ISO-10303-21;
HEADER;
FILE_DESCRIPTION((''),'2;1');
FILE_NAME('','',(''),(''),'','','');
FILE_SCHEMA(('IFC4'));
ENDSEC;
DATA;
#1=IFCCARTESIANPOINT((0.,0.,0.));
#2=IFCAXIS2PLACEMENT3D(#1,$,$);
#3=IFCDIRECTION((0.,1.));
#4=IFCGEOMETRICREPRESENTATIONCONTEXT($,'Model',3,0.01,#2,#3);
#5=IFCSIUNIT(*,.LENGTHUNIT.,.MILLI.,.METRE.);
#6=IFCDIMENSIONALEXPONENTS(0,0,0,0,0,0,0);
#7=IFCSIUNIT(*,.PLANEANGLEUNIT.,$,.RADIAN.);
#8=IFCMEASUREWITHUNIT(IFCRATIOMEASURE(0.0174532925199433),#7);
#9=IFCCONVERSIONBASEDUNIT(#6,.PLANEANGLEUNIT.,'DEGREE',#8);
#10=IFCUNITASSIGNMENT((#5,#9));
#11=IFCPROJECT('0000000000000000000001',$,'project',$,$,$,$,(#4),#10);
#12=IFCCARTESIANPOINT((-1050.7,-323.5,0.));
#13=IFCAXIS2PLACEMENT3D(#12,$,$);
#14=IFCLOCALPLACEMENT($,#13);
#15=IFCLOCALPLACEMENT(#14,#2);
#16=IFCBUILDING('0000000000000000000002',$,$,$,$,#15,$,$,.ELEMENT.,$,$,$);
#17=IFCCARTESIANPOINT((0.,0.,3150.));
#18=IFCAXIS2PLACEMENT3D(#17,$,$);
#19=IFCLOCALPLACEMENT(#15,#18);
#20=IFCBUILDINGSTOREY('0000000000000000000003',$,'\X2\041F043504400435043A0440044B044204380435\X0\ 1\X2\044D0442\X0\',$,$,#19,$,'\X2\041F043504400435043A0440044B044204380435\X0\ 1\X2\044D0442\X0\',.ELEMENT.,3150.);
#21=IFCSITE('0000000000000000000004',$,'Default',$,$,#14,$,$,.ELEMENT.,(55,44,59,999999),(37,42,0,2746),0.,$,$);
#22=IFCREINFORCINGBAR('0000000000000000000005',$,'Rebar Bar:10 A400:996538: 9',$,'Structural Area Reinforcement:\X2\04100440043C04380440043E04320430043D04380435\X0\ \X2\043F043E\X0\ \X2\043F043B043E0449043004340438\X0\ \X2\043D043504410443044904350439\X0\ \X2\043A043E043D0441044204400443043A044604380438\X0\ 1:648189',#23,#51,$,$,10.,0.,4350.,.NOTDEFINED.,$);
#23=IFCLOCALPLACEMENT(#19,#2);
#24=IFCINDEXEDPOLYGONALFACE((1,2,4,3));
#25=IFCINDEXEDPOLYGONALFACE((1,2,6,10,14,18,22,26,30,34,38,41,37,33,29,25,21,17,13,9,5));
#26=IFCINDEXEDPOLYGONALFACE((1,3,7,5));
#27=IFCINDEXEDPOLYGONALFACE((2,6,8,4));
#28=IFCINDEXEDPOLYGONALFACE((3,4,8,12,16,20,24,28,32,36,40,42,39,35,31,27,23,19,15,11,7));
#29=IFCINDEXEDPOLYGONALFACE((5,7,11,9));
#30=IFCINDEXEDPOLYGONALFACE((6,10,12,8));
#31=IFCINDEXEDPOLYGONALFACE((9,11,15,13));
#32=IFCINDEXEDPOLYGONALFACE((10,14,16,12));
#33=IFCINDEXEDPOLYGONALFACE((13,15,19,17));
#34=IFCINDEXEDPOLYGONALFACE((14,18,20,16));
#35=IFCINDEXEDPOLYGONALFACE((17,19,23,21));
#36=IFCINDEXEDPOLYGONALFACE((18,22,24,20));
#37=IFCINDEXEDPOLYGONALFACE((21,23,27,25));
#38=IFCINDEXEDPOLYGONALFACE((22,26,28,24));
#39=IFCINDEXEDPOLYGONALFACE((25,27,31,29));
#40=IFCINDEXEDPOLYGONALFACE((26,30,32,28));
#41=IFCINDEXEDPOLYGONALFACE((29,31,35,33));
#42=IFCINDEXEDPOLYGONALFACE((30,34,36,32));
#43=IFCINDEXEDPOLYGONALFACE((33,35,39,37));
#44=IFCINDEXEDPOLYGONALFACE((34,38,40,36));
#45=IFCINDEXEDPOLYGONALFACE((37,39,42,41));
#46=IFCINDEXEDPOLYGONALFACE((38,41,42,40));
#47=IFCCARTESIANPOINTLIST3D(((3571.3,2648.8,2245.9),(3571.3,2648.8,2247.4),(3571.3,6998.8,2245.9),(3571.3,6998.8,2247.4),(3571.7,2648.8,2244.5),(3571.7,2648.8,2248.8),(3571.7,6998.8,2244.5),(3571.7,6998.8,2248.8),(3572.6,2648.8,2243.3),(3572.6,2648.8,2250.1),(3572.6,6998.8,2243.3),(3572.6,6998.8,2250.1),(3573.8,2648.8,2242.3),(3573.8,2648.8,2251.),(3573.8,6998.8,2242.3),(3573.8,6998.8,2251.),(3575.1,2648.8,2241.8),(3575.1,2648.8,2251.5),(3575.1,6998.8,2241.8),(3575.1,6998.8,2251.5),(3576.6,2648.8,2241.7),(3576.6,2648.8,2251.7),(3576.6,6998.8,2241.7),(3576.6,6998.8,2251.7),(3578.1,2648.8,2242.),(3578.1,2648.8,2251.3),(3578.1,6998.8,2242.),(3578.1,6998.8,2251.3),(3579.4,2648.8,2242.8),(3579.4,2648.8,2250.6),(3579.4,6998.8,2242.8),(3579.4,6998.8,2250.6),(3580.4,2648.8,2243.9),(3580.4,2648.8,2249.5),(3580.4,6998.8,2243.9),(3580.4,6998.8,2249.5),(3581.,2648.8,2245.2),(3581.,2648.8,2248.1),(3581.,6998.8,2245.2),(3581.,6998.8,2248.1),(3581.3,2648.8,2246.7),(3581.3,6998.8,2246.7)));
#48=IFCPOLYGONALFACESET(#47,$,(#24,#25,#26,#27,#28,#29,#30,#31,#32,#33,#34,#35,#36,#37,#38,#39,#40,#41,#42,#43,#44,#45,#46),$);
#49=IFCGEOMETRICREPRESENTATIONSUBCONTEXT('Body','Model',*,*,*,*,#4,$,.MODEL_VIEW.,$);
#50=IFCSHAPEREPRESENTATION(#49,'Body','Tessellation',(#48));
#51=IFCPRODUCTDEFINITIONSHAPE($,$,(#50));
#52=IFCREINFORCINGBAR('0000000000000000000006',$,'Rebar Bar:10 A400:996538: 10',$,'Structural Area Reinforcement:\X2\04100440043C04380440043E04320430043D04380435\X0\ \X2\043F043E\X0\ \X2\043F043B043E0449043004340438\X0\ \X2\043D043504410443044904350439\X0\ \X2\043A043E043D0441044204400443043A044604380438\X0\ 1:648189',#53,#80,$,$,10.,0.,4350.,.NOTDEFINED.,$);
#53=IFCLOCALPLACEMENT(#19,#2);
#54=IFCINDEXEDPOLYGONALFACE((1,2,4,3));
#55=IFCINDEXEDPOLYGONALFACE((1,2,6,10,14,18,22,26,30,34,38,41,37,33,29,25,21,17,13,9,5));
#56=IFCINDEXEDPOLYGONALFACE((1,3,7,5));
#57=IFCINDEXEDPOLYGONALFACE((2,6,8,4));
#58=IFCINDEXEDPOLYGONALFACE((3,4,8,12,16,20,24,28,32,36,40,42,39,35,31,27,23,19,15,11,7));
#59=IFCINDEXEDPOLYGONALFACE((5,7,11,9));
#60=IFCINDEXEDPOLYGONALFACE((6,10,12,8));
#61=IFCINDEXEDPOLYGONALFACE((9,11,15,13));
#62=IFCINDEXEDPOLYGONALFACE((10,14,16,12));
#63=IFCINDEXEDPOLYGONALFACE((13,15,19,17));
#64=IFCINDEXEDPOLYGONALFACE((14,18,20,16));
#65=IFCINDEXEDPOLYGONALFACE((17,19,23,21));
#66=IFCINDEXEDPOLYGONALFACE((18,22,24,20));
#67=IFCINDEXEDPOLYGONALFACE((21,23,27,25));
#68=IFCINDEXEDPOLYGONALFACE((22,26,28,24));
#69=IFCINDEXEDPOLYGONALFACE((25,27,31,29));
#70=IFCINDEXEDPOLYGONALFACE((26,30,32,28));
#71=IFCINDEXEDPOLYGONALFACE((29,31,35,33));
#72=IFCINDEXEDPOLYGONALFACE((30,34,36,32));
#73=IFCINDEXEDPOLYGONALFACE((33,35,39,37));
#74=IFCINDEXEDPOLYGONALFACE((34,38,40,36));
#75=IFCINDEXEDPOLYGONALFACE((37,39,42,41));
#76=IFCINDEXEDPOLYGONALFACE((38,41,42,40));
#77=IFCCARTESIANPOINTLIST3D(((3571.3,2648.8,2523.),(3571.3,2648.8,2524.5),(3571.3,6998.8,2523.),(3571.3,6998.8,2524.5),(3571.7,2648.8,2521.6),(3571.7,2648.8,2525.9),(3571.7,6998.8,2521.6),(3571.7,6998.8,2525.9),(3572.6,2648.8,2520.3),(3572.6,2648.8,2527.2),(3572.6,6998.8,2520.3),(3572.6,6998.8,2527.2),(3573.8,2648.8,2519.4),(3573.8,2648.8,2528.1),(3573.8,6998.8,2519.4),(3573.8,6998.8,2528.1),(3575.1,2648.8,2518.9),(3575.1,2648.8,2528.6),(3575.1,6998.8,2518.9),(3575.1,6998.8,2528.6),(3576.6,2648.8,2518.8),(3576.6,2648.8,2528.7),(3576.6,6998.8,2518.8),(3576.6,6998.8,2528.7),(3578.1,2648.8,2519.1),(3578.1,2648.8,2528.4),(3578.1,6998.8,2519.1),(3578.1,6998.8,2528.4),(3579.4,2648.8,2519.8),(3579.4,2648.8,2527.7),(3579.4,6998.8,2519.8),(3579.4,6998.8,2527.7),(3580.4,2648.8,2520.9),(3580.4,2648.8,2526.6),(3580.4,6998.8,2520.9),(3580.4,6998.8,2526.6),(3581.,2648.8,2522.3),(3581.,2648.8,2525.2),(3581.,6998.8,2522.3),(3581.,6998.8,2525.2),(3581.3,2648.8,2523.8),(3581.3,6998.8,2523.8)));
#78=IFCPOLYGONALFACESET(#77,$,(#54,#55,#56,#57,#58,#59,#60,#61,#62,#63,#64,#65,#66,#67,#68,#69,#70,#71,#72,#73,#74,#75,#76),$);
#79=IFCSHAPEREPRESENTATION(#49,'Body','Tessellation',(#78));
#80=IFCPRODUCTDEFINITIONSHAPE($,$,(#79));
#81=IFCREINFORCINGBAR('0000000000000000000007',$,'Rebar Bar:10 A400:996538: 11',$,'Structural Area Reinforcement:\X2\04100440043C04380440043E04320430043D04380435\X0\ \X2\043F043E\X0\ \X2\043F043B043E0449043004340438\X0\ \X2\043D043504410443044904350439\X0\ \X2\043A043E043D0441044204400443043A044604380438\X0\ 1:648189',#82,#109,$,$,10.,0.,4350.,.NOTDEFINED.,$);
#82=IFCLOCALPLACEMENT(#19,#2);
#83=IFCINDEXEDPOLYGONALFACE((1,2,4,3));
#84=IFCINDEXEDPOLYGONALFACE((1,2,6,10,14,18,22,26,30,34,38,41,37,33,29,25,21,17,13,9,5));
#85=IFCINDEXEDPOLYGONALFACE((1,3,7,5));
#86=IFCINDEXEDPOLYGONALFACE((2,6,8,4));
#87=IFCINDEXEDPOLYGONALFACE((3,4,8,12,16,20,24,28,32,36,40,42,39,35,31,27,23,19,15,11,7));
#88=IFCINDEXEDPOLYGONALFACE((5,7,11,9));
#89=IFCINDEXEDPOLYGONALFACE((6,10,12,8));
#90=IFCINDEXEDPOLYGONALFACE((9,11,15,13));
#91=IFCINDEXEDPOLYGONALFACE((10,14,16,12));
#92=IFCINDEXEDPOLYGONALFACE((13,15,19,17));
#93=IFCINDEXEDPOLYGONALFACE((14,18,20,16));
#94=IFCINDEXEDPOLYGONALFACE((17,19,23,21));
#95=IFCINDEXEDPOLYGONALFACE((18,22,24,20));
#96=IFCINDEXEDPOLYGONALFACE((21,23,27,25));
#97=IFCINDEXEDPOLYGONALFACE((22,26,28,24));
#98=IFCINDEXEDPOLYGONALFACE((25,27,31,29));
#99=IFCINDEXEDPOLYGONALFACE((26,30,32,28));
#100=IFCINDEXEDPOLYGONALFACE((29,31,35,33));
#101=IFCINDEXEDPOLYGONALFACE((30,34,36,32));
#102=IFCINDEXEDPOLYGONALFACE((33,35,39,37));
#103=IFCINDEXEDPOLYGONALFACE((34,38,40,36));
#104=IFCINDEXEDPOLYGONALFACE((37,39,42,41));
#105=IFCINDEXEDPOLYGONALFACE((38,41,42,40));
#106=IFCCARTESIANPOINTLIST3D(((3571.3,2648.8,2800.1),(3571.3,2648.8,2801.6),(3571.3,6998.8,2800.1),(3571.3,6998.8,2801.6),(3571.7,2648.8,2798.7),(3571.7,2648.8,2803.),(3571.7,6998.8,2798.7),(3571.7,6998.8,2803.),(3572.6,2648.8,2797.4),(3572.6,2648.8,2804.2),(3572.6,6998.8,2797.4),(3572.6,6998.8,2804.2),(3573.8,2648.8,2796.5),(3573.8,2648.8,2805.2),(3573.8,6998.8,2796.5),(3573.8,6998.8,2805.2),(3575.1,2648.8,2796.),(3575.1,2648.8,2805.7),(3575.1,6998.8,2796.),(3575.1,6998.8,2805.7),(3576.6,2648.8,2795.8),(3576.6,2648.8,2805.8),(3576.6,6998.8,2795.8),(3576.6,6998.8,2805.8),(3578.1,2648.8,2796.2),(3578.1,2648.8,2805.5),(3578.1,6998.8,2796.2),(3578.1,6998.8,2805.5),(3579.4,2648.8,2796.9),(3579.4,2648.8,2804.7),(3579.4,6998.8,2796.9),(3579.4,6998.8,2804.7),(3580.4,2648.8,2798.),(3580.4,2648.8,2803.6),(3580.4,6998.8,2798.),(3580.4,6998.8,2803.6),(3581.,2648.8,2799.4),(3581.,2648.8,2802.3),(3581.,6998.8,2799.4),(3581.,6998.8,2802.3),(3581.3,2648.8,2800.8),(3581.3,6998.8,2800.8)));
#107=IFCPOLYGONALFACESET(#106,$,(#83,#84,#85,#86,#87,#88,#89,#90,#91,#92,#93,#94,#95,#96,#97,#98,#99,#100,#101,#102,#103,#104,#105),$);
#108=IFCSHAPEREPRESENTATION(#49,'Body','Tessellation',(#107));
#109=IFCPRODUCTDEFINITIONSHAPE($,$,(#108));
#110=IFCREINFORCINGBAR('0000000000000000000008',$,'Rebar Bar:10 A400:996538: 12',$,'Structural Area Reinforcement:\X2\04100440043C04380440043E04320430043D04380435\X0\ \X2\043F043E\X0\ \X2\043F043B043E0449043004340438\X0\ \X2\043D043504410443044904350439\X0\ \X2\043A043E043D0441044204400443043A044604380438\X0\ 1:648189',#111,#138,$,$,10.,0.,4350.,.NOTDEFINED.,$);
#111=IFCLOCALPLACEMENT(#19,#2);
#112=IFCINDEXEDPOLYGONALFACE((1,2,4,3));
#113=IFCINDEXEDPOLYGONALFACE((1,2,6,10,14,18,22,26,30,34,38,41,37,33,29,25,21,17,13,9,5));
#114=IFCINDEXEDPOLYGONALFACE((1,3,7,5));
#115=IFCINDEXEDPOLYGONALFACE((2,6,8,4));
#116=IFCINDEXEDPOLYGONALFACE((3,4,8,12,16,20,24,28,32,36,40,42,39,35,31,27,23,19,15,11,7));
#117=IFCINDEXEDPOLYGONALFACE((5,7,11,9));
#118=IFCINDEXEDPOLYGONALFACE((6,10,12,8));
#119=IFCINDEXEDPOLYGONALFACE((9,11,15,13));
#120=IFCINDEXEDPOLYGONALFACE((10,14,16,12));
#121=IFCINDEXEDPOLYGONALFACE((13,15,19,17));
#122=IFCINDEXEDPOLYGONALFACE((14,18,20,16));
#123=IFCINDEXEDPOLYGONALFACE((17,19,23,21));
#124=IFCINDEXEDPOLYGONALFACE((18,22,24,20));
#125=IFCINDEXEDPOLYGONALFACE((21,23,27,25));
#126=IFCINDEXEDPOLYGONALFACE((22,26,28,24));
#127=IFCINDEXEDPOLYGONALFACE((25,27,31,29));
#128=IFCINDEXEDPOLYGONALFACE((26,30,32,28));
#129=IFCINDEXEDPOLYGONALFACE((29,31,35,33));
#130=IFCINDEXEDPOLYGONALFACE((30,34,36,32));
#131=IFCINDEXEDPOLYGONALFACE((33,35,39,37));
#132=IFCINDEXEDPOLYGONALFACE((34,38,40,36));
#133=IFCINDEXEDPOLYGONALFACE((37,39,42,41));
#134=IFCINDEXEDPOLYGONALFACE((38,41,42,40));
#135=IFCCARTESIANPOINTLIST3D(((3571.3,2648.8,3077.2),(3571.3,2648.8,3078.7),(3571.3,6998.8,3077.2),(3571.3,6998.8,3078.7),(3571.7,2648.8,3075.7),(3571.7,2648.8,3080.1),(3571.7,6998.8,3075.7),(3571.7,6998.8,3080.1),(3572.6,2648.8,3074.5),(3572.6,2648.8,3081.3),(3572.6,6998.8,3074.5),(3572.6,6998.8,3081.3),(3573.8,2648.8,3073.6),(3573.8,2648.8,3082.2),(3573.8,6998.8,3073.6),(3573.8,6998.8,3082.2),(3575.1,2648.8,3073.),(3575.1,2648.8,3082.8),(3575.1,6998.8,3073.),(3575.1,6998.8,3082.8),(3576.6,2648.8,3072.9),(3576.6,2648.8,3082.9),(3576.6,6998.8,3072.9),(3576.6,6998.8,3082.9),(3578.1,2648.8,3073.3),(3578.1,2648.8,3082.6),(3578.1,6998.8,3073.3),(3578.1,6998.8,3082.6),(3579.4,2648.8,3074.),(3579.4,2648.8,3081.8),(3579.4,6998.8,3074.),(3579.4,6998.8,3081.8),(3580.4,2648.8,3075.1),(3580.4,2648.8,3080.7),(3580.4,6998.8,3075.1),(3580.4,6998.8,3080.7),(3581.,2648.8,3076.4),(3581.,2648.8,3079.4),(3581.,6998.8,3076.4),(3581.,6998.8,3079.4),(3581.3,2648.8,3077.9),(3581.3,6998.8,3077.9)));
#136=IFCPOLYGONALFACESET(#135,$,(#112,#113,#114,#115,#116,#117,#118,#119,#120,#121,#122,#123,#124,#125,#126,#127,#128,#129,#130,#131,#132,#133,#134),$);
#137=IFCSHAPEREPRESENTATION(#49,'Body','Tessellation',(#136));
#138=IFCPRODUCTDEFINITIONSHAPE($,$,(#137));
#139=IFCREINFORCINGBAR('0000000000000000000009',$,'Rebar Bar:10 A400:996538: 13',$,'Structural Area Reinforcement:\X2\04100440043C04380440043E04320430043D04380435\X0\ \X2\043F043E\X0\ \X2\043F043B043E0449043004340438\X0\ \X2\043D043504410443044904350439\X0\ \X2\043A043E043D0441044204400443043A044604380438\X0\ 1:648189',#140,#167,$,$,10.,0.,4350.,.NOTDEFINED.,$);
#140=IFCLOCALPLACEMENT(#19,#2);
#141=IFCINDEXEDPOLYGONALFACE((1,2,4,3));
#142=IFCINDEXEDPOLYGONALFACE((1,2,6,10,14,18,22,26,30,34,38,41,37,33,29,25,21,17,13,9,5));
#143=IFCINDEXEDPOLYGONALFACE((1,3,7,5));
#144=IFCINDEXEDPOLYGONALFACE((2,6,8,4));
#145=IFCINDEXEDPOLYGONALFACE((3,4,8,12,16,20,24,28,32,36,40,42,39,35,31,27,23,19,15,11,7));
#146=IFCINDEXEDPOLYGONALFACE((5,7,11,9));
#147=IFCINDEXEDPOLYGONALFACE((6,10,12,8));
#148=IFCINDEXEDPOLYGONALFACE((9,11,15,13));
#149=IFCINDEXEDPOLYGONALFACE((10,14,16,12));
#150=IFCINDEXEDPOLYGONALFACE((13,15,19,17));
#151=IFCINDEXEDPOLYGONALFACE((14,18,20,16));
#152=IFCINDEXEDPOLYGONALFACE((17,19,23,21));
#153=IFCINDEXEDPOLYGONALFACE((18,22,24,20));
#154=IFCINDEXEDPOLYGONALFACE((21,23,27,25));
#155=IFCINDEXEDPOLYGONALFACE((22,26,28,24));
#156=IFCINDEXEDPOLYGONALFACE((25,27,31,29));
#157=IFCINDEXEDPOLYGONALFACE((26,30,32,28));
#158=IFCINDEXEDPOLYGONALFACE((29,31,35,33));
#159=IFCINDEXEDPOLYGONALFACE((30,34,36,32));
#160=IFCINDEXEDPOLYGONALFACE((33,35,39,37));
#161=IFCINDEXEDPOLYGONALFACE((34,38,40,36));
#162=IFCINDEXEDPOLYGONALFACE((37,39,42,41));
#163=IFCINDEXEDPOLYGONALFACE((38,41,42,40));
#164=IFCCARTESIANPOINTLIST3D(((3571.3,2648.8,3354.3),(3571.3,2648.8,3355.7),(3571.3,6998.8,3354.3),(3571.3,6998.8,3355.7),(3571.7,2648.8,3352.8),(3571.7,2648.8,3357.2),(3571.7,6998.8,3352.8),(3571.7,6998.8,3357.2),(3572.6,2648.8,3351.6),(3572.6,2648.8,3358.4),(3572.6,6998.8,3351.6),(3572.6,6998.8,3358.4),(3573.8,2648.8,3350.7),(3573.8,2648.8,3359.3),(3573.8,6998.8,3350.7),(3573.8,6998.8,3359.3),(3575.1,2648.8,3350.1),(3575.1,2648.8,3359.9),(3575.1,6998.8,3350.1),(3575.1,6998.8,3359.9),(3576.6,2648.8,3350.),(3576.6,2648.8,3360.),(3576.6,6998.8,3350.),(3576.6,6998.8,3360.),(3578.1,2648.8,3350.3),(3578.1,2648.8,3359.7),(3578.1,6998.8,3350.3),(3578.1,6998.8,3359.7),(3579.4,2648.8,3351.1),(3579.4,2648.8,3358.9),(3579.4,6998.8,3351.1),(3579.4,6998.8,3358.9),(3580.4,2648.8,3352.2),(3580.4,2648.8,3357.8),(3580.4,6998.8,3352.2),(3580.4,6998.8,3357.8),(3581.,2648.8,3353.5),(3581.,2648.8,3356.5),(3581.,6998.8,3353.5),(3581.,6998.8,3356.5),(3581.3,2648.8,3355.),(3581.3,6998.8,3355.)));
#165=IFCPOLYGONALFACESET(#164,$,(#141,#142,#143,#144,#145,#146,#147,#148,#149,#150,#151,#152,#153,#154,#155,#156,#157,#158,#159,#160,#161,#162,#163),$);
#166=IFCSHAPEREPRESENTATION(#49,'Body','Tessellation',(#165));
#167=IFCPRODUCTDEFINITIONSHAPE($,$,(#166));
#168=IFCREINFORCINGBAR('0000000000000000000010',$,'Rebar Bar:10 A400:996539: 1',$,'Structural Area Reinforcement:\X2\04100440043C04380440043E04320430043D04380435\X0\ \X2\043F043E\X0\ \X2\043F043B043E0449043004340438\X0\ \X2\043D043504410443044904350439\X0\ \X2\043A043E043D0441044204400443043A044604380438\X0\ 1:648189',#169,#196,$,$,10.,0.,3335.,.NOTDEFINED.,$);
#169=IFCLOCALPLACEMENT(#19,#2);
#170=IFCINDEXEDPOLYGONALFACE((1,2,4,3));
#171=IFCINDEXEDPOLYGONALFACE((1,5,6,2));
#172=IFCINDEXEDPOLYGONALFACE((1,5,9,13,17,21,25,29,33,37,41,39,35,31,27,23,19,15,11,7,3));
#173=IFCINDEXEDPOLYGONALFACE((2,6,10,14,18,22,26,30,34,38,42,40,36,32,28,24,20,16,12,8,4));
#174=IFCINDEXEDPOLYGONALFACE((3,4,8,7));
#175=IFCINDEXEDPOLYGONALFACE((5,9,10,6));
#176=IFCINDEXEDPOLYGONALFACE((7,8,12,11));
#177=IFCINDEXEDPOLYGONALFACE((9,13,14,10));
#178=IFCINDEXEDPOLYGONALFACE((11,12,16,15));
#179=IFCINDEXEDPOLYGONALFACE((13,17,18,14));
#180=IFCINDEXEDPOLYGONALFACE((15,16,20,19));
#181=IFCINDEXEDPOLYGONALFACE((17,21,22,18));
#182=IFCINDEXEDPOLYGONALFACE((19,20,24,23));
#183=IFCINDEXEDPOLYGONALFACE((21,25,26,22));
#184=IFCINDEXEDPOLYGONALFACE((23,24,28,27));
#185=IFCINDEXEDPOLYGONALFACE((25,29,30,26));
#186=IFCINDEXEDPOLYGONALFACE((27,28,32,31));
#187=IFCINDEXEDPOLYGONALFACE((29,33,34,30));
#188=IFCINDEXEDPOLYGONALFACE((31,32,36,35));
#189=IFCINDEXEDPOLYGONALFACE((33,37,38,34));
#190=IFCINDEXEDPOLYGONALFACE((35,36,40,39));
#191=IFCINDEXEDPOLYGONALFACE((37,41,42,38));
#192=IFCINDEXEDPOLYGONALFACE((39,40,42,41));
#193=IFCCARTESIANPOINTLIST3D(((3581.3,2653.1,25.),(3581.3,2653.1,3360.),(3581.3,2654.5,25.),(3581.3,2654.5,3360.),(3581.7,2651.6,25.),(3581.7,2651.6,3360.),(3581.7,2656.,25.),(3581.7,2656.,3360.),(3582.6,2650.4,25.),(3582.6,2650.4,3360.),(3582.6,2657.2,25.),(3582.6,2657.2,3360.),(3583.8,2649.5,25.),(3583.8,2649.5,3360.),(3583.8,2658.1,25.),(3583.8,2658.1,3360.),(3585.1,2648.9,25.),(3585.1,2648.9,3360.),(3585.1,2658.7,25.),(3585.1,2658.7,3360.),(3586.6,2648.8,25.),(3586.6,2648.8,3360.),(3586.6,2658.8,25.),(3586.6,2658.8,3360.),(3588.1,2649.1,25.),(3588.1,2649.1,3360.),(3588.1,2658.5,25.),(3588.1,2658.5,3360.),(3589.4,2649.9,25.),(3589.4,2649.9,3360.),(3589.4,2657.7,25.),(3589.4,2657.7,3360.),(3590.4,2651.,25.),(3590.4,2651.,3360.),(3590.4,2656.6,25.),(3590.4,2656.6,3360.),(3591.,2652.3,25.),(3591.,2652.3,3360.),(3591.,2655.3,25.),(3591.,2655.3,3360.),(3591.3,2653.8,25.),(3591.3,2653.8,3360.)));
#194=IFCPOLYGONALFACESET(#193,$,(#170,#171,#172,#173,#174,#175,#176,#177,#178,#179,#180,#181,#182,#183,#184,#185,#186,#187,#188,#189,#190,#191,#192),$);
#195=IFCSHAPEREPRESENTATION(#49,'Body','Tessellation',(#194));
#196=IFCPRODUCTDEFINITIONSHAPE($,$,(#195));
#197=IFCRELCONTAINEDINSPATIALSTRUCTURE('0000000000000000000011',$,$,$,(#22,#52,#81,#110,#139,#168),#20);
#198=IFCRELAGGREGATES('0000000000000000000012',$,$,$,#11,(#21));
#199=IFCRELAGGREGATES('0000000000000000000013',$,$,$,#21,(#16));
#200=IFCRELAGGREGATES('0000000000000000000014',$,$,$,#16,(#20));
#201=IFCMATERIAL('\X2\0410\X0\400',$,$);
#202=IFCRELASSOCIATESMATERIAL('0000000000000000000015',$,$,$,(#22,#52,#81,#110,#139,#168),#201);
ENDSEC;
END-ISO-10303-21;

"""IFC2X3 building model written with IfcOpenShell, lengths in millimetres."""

from ifc_helpers import new_model, entity, si_unit, converted_unit, direction, frame, origin, place, context, subcontext, project, spatial, material, element, save


model = new_model("IFC2X3")

# Units and contexts
model_context = context("Model", 3, precision=0.01, world=origin(), true_north=direction((0.0, 1.0)))
body_context = subcontext(model_context, "Body", "Model", "MODEL_VIEW")
ifc_project = project(units=[si_unit("LENGTHUNIT", "METRE", prefix="MILLI"), converted_unit("PLANEANGLEUNIT", "DEGREE", entity("IfcRatioMeasure", 0.0174532925199433), si_unit("PLANEANGLEUNIT", "RADIAN"), dimensions=[0, 0, 0, 0, 0, 0, 0])], contexts=[model_context])

# Site, building, storey
site_placement = place(None, frame((-1050.7, -323.5, 0.0)))
site = spatial("IfcSite", under=ifc_project, at=site_placement, Name="Default", CompositionType="ELEMENT", RefLatitude=(55, 44, 59, 999999), RefLongitude=(37, 42, 0, 2746), RefElevation=0.0)
building_placement = place(site_placement, origin())
building = spatial("IfcBuilding", under=site, at=building_placement, CompositionType="ELEMENT")
storey_placement = place(building_placement, frame((0.0, 0.0, 3150.0)))
storey = spatial("IfcBuildingStorey", under=building, at=storey_placement, Name="Перекрытие 1эт", LongName="Перекрытие 1эт", CompositionType="ELEMENT", Elevation=3150.0)

# Reinforcing bars
ifc_material = material(Name="А400")
reinforcing_bar_1_placement = place(storey_placement, origin())
element("IfcReinforcingBar", 1, at=reinforcing_bar_1_placement, inside=storey, material=ifc_material, Name="Rebar Bar:10 A400:996538: 9", ObjectType="Structural Area Reinforcement:Армирование по площади несущей конструкции 1:648189", BarLength=4350.0, BarRole="NOTDEFINED", CrossSectionArea=0.0, NominalDiameter=10.0, context=body_context, shape_type="AdvancedSweptSolid", body=[
    entity("IfcSweptDiskSolid", entity("IfcCompositeCurve", [entity("IfcCompositeCurveSegment", "CONTINUOUS", True, entity("IfcPolyline", [entity("IfcCartesianPoint", [3576.3, 2648.8, 2246.7]), entity("IfcCartesianPoint", [3576.3, 6998.8, 2246.7])]))], False), 5.0, None, 0.0, 1.0),
])
reinforcing_bar_2_placement = place(storey_placement, origin())
element("IfcReinforcingBar", 2, at=reinforcing_bar_2_placement, inside=storey, material=ifc_material, Name="Rebar Bar:10 A400:996538: 10", ObjectType="Structural Area Reinforcement:Армирование по площади несущей конструкции 1:648189", BarLength=4350.0, BarRole="NOTDEFINED", CrossSectionArea=0.0, NominalDiameter=10.0, context=body_context, shape_type="AdvancedSweptSolid", body=[
    entity("IfcSweptDiskSolid", entity("IfcCompositeCurve", [entity("IfcCompositeCurveSegment", "CONTINUOUS", True, entity("IfcPolyline", [entity("IfcCartesianPoint", [3576.3, 2648.8, 2523.8]), entity("IfcCartesianPoint", [3576.3, 6998.8, 2523.8])]))], False), 5.0, None, 0.0, 1.0),
])
reinforcing_bar_3_placement = place(storey_placement, origin())
element("IfcReinforcingBar", 3, at=reinforcing_bar_3_placement, inside=storey, material=ifc_material, Name="Rebar Bar:10 A400:996538: 11", ObjectType="Structural Area Reinforcement:Армирование по площади несущей конструкции 1:648189", BarLength=4350.0, BarRole="NOTDEFINED", CrossSectionArea=0.0, NominalDiameter=10.0, context=body_context, shape_type="AdvancedSweptSolid", body=[
    entity("IfcSweptDiskSolid", entity("IfcCompositeCurve", [entity("IfcCompositeCurveSegment", "CONTINUOUS", True, entity("IfcPolyline", [entity("IfcCartesianPoint", [3576.3, 2648.8, 2800.8]), entity("IfcCartesianPoint", [3576.3, 6998.8, 2800.8])]))], False), 5.0, None, 0.0, 1.0),
])
reinforcing_bar_4_placement = place(storey_placement, origin())
element("IfcReinforcingBar", 4, at=reinforcing_bar_4_placement, inside=storey, material=ifc_material, Name="Rebar Bar:10 A400:996538: 12", ObjectType="Structural Area Reinforcement:Армирование по площади несущей конструкции 1:648189", BarLength=4350.0, BarRole="NOTDEFINED", CrossSectionArea=0.0, NominalDiameter=10.0, context=body_context, shape_type="AdvancedSweptSolid", body=[
    entity("IfcSweptDiskSolid", entity("IfcCompositeCurve", [entity("IfcCompositeCurveSegment", "CONTINUOUS", True, entity("IfcPolyline", [entity("IfcCartesianPoint", [3576.3, 2648.8, 3077.9]), entity("IfcCartesianPoint", [3576.3, 6998.8, 3077.9])]))], False), 5.0, None, 0.0, 1.0),
])
reinforcing_bar_5_placement = place(storey_placement, origin())
element("IfcReinforcingBar", 5, at=reinforcing_bar_5_placement, inside=storey, material=ifc_material, Name="Rebar Bar:10 A400:996538: 13", ObjectType="Structural Area Reinforcement:Армирование по площади несущей конструкции 1:648189", BarLength=4350.0, BarRole="NOTDEFINED", CrossSectionArea=0.0, NominalDiameter=10.0, context=body_context, shape_type="AdvancedSweptSolid", body=[
    entity("IfcSweptDiskSolid", entity("IfcCompositeCurve", [entity("IfcCompositeCurveSegment", "CONTINUOUS", True, entity("IfcPolyline", [entity("IfcCartesianPoint", [3576.3, 2648.8, 3355.0]), entity("IfcCartesianPoint", [3576.3, 6998.8, 3355.0])]))], False), 5.0, None, 0.0, 1.0),
])
reinforcing_bar_6_placement = place(storey_placement, origin())
element("IfcReinforcingBar", 6, at=reinforcing_bar_6_placement, inside=storey, material=ifc_material, Name="Rebar Bar:10 A400:996539: 1", ObjectType="Structural Area Reinforcement:Армирование по площади несущей конструкции 1:648189", BarLength=3335.0, BarRole="NOTDEFINED", CrossSectionArea=0.0, NominalDiameter=10.0, context=body_context, shape_type="AdvancedSweptSolid", body=[
    entity("IfcSweptDiskSolid", entity("IfcCompositeCurve", [entity("IfcCompositeCurveSegment", "CONTINUOUS", True, entity("IfcPolyline", [entity("IfcCartesianPoint", [3586.3, 2653.8, 25.0]), entity("IfcCartesianPoint", [3586.3, 2653.8, 3360.0])]))], False), 5.0, None, 0.0, 1.0),
])

save(model, "model.ifc")
